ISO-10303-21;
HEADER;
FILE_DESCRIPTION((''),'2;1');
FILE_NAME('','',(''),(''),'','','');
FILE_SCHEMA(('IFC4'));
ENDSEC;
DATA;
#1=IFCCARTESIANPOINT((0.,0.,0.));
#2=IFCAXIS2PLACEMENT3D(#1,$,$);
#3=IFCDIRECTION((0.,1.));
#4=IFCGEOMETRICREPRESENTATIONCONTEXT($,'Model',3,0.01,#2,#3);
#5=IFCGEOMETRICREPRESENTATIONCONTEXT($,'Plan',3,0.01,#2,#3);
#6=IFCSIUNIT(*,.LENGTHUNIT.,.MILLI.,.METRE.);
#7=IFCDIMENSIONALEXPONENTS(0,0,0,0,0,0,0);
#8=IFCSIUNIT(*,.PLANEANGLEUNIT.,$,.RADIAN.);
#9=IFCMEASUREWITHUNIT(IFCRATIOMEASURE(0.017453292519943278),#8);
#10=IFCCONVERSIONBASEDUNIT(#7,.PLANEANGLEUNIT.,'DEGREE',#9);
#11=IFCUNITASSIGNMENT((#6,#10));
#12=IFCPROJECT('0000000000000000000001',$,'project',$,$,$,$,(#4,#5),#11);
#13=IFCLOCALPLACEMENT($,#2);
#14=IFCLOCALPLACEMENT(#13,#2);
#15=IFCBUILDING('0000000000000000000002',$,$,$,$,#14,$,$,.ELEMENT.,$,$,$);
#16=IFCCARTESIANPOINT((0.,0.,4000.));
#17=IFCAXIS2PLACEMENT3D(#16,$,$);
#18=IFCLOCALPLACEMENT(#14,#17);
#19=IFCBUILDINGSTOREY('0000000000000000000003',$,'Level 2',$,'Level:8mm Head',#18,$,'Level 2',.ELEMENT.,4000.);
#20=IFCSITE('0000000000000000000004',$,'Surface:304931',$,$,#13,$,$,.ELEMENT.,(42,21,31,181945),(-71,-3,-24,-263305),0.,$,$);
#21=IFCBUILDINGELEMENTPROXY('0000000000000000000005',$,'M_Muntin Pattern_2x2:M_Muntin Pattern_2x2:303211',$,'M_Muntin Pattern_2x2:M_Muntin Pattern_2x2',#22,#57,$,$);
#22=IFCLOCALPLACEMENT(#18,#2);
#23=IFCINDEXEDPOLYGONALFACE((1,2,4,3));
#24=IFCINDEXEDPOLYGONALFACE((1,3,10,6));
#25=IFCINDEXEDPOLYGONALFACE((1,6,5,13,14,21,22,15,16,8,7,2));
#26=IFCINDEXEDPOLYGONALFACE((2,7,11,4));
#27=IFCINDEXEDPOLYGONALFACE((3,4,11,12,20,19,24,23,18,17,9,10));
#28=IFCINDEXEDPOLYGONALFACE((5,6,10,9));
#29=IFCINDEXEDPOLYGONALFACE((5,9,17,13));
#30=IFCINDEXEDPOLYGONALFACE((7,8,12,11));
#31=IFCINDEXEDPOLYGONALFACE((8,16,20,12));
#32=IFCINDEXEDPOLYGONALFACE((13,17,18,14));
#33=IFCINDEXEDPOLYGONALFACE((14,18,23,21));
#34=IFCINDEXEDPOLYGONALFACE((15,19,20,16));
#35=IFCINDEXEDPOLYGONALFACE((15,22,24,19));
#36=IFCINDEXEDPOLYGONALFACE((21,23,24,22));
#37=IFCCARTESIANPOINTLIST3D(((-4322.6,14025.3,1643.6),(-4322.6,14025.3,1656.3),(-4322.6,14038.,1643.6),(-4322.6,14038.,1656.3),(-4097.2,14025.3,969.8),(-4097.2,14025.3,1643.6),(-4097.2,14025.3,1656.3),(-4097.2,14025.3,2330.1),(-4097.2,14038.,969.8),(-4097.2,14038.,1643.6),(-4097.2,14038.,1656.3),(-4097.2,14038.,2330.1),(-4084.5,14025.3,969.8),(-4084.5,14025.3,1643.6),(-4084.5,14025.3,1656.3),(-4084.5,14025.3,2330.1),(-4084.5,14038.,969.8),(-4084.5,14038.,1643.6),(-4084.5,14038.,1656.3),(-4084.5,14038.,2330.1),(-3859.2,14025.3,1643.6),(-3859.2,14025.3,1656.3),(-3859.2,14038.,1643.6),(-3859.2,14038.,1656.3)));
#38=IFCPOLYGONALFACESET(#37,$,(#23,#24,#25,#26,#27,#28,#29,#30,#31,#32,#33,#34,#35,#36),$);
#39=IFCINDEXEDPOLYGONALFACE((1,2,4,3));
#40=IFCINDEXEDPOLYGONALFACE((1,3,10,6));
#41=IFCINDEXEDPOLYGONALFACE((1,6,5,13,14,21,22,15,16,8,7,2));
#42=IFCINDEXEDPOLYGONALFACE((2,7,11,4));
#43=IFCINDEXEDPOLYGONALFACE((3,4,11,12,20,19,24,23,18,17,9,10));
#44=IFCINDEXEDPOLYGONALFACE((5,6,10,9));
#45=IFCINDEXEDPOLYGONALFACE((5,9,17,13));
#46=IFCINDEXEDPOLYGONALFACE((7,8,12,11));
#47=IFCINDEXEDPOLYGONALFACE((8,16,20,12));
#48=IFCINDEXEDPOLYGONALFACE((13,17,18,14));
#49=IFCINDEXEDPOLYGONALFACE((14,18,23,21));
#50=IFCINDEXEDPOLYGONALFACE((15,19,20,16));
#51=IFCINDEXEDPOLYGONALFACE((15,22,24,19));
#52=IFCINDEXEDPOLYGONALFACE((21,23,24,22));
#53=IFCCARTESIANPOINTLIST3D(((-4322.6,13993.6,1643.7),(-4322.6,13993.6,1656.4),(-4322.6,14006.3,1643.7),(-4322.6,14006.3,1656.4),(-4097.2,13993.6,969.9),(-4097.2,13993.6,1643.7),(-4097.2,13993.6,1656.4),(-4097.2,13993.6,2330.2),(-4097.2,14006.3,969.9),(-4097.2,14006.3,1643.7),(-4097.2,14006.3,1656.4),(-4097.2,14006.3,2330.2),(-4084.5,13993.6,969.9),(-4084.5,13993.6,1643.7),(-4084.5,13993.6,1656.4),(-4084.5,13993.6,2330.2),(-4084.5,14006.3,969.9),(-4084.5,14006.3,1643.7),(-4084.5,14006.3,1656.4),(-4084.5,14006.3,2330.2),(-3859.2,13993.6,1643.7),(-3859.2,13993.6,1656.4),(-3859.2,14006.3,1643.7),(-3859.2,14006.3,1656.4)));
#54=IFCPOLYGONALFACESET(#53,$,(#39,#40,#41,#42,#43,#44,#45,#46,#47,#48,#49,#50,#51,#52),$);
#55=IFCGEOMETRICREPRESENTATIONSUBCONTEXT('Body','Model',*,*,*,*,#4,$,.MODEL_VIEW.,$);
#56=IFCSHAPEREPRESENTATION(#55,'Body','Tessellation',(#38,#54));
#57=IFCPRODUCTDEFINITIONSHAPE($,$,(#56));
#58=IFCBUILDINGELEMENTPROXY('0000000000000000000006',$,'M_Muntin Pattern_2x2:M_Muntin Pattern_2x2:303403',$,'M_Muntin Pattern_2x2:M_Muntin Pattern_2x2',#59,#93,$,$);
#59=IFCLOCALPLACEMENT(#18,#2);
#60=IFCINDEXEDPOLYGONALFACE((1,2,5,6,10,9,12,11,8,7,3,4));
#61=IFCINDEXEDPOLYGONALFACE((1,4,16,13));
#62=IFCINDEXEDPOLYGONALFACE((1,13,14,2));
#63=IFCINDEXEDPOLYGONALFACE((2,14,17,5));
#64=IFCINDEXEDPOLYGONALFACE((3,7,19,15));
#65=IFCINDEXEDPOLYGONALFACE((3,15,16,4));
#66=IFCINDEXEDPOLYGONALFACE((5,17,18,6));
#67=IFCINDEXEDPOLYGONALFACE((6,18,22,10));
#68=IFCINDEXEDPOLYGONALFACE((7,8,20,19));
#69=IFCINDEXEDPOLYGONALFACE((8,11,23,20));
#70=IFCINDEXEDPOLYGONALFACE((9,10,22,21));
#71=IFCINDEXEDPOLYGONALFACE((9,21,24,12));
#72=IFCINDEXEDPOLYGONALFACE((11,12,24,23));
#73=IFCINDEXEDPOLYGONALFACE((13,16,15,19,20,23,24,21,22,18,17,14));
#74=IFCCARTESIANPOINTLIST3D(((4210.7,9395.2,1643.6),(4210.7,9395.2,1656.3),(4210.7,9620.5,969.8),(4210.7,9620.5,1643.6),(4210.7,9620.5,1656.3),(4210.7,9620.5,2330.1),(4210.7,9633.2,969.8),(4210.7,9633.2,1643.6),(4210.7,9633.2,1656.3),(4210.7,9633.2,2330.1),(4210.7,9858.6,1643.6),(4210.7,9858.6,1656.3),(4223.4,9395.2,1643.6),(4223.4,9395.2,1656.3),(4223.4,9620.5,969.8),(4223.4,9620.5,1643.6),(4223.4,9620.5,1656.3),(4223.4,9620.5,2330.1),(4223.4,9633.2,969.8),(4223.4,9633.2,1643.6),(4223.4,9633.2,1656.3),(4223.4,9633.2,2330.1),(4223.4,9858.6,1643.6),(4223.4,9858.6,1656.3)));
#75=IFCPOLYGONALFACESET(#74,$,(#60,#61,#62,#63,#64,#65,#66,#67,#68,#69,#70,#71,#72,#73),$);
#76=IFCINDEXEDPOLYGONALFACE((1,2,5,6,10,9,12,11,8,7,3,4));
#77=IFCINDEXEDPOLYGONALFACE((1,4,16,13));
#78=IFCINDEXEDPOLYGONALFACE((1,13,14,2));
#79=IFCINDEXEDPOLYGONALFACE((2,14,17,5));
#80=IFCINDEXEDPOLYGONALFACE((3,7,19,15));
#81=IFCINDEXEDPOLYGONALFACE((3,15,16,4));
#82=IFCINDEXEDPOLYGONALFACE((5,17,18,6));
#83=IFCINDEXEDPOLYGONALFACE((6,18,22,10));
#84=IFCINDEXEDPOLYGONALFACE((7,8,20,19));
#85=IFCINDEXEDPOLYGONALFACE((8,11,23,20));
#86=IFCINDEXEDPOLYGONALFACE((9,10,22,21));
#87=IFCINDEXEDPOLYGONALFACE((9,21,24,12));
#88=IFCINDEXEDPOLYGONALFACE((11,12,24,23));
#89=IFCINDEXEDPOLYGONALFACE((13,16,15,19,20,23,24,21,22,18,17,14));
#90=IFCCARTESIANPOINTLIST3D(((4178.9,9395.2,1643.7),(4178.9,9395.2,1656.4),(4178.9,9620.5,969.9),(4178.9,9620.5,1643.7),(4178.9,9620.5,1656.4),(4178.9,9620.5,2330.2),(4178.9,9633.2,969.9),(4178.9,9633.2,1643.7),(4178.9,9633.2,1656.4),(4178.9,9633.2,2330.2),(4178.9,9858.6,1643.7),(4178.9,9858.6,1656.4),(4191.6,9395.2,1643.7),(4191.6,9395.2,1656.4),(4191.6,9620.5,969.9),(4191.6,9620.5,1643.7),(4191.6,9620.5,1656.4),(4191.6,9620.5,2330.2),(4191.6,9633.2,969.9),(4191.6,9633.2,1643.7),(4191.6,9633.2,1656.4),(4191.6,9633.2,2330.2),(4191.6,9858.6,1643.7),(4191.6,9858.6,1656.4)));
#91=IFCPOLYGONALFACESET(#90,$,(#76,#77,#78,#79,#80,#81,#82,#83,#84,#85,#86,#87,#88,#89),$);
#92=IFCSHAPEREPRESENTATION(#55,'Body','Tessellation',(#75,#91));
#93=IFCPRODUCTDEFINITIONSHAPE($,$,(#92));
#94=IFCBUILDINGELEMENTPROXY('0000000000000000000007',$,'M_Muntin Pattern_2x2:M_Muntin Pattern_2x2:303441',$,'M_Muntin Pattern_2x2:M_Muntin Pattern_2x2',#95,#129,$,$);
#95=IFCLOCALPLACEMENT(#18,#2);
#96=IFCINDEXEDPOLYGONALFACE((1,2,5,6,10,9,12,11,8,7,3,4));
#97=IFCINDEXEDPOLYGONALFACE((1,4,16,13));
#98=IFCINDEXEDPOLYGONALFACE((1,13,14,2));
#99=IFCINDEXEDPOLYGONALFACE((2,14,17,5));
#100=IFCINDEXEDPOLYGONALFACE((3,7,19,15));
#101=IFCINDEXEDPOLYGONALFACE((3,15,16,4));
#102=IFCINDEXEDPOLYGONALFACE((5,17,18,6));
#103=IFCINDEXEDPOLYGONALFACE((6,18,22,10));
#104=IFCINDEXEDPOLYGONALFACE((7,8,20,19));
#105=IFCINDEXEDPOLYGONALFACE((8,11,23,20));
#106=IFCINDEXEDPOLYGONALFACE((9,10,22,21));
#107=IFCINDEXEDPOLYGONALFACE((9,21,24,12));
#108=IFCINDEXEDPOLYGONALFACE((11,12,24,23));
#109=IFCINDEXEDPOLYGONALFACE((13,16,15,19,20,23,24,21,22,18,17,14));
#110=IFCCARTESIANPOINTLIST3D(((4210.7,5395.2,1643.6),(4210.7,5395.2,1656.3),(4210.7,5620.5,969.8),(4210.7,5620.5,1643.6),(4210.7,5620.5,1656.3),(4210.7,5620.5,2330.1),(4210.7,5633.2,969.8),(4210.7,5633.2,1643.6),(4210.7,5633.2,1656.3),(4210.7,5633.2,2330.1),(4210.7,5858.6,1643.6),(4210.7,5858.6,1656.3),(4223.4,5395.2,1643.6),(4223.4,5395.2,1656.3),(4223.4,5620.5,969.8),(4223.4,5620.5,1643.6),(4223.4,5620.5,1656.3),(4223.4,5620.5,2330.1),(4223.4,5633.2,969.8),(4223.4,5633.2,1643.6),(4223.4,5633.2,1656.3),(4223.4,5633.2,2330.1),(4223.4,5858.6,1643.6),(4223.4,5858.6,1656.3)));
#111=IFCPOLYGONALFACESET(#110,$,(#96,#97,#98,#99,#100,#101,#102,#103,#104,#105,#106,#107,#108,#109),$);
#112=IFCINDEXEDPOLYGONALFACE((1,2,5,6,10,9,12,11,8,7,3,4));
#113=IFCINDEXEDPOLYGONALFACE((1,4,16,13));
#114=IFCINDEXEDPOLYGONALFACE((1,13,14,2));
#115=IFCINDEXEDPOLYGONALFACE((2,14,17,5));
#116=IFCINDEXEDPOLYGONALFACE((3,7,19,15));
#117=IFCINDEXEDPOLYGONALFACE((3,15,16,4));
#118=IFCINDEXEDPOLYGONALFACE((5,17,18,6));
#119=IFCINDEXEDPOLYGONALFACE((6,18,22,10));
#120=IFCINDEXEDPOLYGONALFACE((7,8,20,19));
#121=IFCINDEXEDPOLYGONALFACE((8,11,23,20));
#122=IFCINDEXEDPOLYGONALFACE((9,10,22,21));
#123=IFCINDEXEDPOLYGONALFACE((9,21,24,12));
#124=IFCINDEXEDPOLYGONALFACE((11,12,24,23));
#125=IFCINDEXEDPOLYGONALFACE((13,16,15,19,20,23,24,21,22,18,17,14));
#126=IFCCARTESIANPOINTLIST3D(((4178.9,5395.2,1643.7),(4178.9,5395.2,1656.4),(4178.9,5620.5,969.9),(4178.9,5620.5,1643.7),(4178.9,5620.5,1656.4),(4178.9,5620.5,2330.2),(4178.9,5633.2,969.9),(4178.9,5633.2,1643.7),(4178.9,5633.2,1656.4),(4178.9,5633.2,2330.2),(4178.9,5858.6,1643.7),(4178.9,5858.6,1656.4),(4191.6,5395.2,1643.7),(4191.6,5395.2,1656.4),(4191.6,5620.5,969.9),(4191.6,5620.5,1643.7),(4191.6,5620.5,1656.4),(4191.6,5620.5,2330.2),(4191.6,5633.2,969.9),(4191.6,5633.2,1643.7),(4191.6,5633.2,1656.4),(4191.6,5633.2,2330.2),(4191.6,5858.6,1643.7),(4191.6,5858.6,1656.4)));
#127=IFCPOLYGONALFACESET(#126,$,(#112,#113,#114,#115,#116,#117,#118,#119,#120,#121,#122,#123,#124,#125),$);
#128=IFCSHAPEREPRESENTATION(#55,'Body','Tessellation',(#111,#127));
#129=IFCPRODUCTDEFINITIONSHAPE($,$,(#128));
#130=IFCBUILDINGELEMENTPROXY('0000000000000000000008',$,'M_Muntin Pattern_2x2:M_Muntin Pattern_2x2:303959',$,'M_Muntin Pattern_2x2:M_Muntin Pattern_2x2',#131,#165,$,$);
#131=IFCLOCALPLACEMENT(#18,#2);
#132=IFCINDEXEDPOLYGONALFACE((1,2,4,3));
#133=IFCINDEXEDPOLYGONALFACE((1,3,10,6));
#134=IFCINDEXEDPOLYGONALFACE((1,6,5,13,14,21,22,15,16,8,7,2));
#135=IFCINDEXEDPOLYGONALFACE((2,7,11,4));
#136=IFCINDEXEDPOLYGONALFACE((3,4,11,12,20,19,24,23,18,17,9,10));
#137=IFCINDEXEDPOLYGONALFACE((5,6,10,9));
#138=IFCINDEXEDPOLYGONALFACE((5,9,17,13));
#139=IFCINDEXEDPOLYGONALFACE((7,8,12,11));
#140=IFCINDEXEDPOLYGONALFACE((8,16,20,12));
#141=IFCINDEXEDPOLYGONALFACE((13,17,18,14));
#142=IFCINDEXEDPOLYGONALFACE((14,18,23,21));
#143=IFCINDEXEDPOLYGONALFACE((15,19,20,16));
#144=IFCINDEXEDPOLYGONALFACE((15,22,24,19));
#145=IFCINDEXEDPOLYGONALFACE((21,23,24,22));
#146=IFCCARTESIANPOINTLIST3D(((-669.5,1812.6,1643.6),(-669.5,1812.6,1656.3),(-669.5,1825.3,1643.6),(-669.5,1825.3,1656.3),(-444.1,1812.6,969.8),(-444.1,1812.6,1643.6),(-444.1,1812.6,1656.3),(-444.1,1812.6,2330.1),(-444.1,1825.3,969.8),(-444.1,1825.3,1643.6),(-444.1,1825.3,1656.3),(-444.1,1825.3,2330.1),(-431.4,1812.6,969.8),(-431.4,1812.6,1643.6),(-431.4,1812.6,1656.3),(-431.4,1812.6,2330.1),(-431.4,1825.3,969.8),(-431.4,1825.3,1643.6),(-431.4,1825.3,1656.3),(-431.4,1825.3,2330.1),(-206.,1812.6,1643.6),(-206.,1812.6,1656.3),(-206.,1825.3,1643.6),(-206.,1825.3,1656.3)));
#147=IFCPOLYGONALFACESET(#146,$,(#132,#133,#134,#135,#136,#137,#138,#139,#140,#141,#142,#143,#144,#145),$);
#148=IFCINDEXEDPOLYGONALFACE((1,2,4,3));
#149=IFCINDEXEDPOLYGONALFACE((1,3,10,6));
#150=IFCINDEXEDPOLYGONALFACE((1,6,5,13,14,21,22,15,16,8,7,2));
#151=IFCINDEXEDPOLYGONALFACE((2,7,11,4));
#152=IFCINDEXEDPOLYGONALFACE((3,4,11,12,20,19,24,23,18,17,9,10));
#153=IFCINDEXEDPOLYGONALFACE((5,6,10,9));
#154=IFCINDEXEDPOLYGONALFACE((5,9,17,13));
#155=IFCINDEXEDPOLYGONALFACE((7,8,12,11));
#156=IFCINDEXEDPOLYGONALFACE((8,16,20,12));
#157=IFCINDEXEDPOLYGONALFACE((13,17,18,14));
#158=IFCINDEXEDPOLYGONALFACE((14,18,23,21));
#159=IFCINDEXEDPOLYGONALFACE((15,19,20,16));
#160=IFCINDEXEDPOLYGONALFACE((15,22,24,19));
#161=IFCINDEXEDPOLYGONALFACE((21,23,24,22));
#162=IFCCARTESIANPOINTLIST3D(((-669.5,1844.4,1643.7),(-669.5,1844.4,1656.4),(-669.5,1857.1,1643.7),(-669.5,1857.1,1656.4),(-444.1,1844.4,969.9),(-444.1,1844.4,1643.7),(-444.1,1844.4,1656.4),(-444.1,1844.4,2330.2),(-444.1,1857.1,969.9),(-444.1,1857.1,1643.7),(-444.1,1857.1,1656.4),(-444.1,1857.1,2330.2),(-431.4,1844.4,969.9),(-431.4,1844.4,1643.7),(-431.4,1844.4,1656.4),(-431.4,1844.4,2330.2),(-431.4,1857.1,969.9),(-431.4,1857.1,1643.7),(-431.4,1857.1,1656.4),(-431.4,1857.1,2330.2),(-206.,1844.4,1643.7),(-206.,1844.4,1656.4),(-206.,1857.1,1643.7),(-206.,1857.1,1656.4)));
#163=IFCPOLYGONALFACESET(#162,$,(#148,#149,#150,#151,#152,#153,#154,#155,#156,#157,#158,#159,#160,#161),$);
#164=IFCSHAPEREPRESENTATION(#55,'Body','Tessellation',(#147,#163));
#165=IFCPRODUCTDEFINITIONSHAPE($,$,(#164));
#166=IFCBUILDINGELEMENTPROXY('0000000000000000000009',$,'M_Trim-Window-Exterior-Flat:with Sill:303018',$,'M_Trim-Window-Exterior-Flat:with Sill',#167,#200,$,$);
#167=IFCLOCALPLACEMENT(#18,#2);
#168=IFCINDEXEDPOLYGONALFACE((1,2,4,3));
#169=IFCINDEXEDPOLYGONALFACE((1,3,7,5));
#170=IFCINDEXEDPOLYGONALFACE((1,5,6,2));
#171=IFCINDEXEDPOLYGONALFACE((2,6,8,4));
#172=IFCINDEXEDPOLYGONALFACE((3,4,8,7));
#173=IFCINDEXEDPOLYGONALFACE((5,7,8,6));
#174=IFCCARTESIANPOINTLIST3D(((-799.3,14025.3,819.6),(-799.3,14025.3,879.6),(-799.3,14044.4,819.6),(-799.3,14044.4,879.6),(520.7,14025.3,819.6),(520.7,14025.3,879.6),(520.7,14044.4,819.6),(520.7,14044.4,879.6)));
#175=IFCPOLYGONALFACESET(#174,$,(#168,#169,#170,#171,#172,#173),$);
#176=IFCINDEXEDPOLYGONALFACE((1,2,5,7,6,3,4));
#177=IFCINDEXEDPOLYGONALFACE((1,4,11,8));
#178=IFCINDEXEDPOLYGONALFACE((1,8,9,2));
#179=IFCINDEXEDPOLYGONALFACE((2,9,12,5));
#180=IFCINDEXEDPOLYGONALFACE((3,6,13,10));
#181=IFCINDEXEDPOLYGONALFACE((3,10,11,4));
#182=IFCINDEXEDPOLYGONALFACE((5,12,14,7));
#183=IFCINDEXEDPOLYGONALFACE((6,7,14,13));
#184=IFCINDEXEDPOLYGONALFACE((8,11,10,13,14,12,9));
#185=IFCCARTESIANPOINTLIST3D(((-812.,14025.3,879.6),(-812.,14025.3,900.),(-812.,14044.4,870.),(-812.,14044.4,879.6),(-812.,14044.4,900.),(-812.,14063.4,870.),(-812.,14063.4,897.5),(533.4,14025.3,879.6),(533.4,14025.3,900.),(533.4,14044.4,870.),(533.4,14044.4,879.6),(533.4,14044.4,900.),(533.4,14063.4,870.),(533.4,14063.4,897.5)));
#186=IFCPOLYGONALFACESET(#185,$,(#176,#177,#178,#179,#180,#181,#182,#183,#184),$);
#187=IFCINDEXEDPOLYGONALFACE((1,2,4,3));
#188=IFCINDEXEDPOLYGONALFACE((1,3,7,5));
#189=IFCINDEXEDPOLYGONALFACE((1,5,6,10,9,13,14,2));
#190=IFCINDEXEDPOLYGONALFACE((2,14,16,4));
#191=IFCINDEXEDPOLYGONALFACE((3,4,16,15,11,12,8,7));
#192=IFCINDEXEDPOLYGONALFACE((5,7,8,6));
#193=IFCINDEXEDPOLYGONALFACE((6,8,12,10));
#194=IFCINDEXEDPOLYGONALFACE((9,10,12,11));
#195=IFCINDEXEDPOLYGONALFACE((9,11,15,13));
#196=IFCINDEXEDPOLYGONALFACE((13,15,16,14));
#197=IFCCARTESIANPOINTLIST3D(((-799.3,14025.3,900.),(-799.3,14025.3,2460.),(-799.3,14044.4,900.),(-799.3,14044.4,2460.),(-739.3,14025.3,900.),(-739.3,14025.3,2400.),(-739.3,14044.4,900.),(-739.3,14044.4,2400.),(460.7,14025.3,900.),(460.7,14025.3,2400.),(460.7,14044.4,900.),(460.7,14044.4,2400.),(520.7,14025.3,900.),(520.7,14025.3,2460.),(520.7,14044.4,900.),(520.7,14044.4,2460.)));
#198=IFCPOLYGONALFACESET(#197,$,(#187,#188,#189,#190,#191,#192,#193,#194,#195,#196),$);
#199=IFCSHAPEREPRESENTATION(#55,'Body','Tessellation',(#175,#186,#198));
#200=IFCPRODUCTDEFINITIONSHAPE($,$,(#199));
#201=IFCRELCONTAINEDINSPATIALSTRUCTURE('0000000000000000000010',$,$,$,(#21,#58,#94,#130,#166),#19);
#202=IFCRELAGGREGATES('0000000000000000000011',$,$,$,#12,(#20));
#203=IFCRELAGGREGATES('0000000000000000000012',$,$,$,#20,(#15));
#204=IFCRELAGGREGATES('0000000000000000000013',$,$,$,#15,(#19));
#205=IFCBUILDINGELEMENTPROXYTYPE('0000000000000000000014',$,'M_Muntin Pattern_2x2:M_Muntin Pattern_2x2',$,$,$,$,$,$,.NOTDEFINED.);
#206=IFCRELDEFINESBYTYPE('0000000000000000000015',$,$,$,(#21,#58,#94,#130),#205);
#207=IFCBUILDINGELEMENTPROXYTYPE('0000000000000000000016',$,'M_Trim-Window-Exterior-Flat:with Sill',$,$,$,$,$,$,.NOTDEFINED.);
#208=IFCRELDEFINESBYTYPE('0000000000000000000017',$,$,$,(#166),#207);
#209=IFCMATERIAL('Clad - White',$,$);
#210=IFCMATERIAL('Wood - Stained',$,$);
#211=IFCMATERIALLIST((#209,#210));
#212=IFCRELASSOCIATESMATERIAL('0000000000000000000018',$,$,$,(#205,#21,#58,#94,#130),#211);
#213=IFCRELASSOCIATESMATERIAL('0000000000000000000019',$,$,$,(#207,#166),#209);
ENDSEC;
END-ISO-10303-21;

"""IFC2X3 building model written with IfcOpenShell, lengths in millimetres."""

from ifc_helpers import new_model, entity, si_unit, converted_unit, direction, frame, frame_2d, origin, place, context, subcontext, project, spatial, polyline, rectangle, outline, extrude, source, transform, mapped, material, material_list, type_object, type_shapes, element, save


model = new_model("IFC2X3")

# Units and contexts
model_context = context("Model", 3, precision=0.01, world=origin(), true_north=direction((0.0, 1.0)))
plan_context = context("Plan", 3, precision=0.01, world=origin(), true_north=direction((0.0, 1.0)))
body_context = subcontext(model_context, "Body", "Model", "MODEL_VIEW")
ifc_project = project(units=[si_unit("LENGTHUNIT", "METRE", prefix="MILLI"), converted_unit("PLANEANGLEUNIT", "DEGREE", entity("IfcRatioMeasure", 0.017453292519943278), si_unit("PLANEANGLEUNIT", "RADIAN"), dimensions=[0, 0, 0, 0, 0, 0, 0])], contexts=[model_context, plan_context])

# Site, building, storey
site_placement = place(None, origin())
site = spatial("IfcSite", under=ifc_project, at=site_placement, Name="Surface:304931", CompositionType="ELEMENT", RefLatitude=(42, 21, 31, 181945), RefLongitude=(-71, -3, -24, -263305), RefElevation=0.0)
building_placement = place(site_placement, origin())
building = spatial("IfcBuilding", under=site, at=building_placement, CompositionType="ELEMENT")
storey_placement = place(building_placement, frame((0.0, 0.0, 4000.0)))
storey = spatial("IfcBuildingStorey", under=building, at=storey_placement, Name="Level 2", ObjectType="Level:8mm Head", LongName="Level 2", CompositionType="ELEMENT", Elevation=4000.0)

# Building element proxies
ifc_material_1 = material(Name="Clad - White")
ifc_material_2 = material(Name="Wood - Stained")
ifc_material_list = material_list([ifc_material_1, ifc_material_2])
building_element_proxy_type_1 = type_object("IfcBuildingElementProxyType", Name="M_Muntin Pattern_2x2:M_Muntin Pattern_2x2", PredefinedType="NOTDEFINED", material=ifc_material_list)
shared_shape_1 = source(origin(), body_context, "Body", "SweptSolid", [
    extrude(outline(polyline([(6.4, -6.4), (680.1, -6.4), (680.1, 6.3), (6.4, 6.3), (6.4, 231.7), (-6.3, 231.7), (-6.3, 6.3), (-680.2, 6.3), (-680.2, -6.4), (-6.3, -6.4), (-6.3, -231.7), (6.4, -231.7), (6.4, -6.4)])), frame((0.0, -22.2, 680.1), z_axis=(0.0, 1.0, 0.0), x_axis=(0.0, 0.0, 1.0)), (0.0, 0.0, 1.0), 12.7),
    extrude(outline(polyline([(6.4, -6.4), (680.2, -6.4), (680.2, 6.3), (6.4, 6.3), (6.4, 231.7), (-6.3, 231.7), (-6.3, 6.3), (-680.2, 6.3), (-680.2, -6.4), (-6.3, -6.4), (-6.3, -231.7), (6.4, -231.7), (6.4, -6.4)])), frame((0.0, 9.5, 680.2), z_axis=(0.0, 1.0, 0.0), x_axis=(0.0, 0.0, 1.0)), (0.0, 0.0, 1.0), 12.7),
])
type_shapes(building_element_proxy_type_1, [shared_shape_1])
for number, where, z_axis, x_axis, name in (
    (1, (-4090.9, 14015.8, 969.9), (0.0, 0.0, 1.0), (-1.0, 0.0, 0.0), "M_Muntin Pattern_2x2:M_Muntin Pattern_2x2:303211"),
    (2, (4201.2, 9626.9, 969.9), (0.0, 0.0, 1.0), (0.0, 1.0, 0.0), "M_Muntin Pattern_2x2:M_Muntin Pattern_2x2:303403"),
    (3, (4201.2, 5626.9, 969.9), (0.0, 0.0, 1.0), (0.0, 1.0, 0.0), "M_Muntin Pattern_2x2:M_Muntin Pattern_2x2:303441"),
):
    element("IfcBuildingElementProxy", number, at=place(storey_placement, frame(where, z_axis=z_axis, x_axis=x_axis)), inside=storey, type_object=building_element_proxy_type_1, material=ifc_material_list, Name=name, ObjectType="M_Muntin Pattern_2x2:M_Muntin Pattern_2x2", context=body_context, shape_type="MappedRepresentation", body=[
        mapped(shared_shape_1, transform((0.0, 0.0, 0.0), scale=1.0)),
    ])
proxy_1_placement = place(storey_placement, frame((-437.7, 1834.8, 969.9)))
element("IfcBuildingElementProxy", 4, at=proxy_1_placement, inside=storey, type_object=building_element_proxy_type_1, material=ifc_material_list, Name="M_Muntin Pattern_2x2:M_Muntin Pattern_2x2:303959", ObjectType="M_Muntin Pattern_2x2:M_Muntin Pattern_2x2", context=body_context, shape_type="MappedRepresentation", body=[
    mapped(shared_shape_1, transform((0.0, 0.0, 0.0), scale=1.0)),
])
building_element_proxy_type_2 = type_object("IfcBuildingElementProxyType", Name="M_Trim-Window-Exterior-Flat:with Sill", PredefinedType="NOTDEFINED", material=ifc_material_1)
shared_shape_2 = source(origin(), body_context, "Body", "SweptSolid", [
    extrude(rectangle(XDim=1320.0, YDim=60.0, at=frame_2d((0.0, 0.0), x_axis=(1.0, 0.0))), frame((0.0, -1550.4, 0.0), z_axis=(0.0, 0.0, 1.0), x_axis=(-1.0, 0.0, 0.0)), (0.0, 0.0, 1.0), 19.0),
    extrude(outline(polyline([(-19.0, -15.2), (0.0, -15.2), (0.0, -5.7), (19.0, -5.7), (19.0, 14.8), (0.0, 14.8), (-19.0, 12.3), (-19.0, -15.2)])), frame((-672.7, -1514.8, 19.0), z_axis=(1.0, 0.0, 0.0), x_axis=(0.0, 0.0, -1.0)), (0.0, 0.0, 1.0), 1345.4),
    extrude(outline(polyline([(-795.0, -660.0), (765.0, -660.0), (765.0, -600.0), (-735.0, -600.0), (-735.0, 600.0), (765.0, 600.0), (765.0, 660.0), (-795.0, 660.0), (-795.0, -660.0)])), frame((0.0, -735.0, 0.0), z_axis=(0.0, 0.0, 1.0), x_axis=(0.0, -1.0, 0.0)), (0.0, 0.0, 1.0), 19.0),
])
type_shapes(building_element_proxy_type_2, [shared_shape_2])
for number, where, z_axis, x_axis, name in (
    (5, (-139.3, 14025.3, 2400.0), (0.0, 1.0, 0.0), (-1.0, 0.0, 0.0), "M_Trim-Window-Exterior-Flat:with Sill:303018"),
):
    element("IfcBuildingElementProxy", number, at=place(storey_placement, frame(where, z_axis=z_axis, x_axis=x_axis)), inside=storey, type_object=building_element_proxy_type_2, material=ifc_material_1, Name=name, ObjectType="M_Trim-Window-Exterior-Flat:with Sill", context=body_context, shape_type="MappedRepresentation", body=[
        mapped(shared_shape_2, transform((0.0, 0.0, 0.0), scale=1.0)),
    ])

save(model, "model.ifc")
